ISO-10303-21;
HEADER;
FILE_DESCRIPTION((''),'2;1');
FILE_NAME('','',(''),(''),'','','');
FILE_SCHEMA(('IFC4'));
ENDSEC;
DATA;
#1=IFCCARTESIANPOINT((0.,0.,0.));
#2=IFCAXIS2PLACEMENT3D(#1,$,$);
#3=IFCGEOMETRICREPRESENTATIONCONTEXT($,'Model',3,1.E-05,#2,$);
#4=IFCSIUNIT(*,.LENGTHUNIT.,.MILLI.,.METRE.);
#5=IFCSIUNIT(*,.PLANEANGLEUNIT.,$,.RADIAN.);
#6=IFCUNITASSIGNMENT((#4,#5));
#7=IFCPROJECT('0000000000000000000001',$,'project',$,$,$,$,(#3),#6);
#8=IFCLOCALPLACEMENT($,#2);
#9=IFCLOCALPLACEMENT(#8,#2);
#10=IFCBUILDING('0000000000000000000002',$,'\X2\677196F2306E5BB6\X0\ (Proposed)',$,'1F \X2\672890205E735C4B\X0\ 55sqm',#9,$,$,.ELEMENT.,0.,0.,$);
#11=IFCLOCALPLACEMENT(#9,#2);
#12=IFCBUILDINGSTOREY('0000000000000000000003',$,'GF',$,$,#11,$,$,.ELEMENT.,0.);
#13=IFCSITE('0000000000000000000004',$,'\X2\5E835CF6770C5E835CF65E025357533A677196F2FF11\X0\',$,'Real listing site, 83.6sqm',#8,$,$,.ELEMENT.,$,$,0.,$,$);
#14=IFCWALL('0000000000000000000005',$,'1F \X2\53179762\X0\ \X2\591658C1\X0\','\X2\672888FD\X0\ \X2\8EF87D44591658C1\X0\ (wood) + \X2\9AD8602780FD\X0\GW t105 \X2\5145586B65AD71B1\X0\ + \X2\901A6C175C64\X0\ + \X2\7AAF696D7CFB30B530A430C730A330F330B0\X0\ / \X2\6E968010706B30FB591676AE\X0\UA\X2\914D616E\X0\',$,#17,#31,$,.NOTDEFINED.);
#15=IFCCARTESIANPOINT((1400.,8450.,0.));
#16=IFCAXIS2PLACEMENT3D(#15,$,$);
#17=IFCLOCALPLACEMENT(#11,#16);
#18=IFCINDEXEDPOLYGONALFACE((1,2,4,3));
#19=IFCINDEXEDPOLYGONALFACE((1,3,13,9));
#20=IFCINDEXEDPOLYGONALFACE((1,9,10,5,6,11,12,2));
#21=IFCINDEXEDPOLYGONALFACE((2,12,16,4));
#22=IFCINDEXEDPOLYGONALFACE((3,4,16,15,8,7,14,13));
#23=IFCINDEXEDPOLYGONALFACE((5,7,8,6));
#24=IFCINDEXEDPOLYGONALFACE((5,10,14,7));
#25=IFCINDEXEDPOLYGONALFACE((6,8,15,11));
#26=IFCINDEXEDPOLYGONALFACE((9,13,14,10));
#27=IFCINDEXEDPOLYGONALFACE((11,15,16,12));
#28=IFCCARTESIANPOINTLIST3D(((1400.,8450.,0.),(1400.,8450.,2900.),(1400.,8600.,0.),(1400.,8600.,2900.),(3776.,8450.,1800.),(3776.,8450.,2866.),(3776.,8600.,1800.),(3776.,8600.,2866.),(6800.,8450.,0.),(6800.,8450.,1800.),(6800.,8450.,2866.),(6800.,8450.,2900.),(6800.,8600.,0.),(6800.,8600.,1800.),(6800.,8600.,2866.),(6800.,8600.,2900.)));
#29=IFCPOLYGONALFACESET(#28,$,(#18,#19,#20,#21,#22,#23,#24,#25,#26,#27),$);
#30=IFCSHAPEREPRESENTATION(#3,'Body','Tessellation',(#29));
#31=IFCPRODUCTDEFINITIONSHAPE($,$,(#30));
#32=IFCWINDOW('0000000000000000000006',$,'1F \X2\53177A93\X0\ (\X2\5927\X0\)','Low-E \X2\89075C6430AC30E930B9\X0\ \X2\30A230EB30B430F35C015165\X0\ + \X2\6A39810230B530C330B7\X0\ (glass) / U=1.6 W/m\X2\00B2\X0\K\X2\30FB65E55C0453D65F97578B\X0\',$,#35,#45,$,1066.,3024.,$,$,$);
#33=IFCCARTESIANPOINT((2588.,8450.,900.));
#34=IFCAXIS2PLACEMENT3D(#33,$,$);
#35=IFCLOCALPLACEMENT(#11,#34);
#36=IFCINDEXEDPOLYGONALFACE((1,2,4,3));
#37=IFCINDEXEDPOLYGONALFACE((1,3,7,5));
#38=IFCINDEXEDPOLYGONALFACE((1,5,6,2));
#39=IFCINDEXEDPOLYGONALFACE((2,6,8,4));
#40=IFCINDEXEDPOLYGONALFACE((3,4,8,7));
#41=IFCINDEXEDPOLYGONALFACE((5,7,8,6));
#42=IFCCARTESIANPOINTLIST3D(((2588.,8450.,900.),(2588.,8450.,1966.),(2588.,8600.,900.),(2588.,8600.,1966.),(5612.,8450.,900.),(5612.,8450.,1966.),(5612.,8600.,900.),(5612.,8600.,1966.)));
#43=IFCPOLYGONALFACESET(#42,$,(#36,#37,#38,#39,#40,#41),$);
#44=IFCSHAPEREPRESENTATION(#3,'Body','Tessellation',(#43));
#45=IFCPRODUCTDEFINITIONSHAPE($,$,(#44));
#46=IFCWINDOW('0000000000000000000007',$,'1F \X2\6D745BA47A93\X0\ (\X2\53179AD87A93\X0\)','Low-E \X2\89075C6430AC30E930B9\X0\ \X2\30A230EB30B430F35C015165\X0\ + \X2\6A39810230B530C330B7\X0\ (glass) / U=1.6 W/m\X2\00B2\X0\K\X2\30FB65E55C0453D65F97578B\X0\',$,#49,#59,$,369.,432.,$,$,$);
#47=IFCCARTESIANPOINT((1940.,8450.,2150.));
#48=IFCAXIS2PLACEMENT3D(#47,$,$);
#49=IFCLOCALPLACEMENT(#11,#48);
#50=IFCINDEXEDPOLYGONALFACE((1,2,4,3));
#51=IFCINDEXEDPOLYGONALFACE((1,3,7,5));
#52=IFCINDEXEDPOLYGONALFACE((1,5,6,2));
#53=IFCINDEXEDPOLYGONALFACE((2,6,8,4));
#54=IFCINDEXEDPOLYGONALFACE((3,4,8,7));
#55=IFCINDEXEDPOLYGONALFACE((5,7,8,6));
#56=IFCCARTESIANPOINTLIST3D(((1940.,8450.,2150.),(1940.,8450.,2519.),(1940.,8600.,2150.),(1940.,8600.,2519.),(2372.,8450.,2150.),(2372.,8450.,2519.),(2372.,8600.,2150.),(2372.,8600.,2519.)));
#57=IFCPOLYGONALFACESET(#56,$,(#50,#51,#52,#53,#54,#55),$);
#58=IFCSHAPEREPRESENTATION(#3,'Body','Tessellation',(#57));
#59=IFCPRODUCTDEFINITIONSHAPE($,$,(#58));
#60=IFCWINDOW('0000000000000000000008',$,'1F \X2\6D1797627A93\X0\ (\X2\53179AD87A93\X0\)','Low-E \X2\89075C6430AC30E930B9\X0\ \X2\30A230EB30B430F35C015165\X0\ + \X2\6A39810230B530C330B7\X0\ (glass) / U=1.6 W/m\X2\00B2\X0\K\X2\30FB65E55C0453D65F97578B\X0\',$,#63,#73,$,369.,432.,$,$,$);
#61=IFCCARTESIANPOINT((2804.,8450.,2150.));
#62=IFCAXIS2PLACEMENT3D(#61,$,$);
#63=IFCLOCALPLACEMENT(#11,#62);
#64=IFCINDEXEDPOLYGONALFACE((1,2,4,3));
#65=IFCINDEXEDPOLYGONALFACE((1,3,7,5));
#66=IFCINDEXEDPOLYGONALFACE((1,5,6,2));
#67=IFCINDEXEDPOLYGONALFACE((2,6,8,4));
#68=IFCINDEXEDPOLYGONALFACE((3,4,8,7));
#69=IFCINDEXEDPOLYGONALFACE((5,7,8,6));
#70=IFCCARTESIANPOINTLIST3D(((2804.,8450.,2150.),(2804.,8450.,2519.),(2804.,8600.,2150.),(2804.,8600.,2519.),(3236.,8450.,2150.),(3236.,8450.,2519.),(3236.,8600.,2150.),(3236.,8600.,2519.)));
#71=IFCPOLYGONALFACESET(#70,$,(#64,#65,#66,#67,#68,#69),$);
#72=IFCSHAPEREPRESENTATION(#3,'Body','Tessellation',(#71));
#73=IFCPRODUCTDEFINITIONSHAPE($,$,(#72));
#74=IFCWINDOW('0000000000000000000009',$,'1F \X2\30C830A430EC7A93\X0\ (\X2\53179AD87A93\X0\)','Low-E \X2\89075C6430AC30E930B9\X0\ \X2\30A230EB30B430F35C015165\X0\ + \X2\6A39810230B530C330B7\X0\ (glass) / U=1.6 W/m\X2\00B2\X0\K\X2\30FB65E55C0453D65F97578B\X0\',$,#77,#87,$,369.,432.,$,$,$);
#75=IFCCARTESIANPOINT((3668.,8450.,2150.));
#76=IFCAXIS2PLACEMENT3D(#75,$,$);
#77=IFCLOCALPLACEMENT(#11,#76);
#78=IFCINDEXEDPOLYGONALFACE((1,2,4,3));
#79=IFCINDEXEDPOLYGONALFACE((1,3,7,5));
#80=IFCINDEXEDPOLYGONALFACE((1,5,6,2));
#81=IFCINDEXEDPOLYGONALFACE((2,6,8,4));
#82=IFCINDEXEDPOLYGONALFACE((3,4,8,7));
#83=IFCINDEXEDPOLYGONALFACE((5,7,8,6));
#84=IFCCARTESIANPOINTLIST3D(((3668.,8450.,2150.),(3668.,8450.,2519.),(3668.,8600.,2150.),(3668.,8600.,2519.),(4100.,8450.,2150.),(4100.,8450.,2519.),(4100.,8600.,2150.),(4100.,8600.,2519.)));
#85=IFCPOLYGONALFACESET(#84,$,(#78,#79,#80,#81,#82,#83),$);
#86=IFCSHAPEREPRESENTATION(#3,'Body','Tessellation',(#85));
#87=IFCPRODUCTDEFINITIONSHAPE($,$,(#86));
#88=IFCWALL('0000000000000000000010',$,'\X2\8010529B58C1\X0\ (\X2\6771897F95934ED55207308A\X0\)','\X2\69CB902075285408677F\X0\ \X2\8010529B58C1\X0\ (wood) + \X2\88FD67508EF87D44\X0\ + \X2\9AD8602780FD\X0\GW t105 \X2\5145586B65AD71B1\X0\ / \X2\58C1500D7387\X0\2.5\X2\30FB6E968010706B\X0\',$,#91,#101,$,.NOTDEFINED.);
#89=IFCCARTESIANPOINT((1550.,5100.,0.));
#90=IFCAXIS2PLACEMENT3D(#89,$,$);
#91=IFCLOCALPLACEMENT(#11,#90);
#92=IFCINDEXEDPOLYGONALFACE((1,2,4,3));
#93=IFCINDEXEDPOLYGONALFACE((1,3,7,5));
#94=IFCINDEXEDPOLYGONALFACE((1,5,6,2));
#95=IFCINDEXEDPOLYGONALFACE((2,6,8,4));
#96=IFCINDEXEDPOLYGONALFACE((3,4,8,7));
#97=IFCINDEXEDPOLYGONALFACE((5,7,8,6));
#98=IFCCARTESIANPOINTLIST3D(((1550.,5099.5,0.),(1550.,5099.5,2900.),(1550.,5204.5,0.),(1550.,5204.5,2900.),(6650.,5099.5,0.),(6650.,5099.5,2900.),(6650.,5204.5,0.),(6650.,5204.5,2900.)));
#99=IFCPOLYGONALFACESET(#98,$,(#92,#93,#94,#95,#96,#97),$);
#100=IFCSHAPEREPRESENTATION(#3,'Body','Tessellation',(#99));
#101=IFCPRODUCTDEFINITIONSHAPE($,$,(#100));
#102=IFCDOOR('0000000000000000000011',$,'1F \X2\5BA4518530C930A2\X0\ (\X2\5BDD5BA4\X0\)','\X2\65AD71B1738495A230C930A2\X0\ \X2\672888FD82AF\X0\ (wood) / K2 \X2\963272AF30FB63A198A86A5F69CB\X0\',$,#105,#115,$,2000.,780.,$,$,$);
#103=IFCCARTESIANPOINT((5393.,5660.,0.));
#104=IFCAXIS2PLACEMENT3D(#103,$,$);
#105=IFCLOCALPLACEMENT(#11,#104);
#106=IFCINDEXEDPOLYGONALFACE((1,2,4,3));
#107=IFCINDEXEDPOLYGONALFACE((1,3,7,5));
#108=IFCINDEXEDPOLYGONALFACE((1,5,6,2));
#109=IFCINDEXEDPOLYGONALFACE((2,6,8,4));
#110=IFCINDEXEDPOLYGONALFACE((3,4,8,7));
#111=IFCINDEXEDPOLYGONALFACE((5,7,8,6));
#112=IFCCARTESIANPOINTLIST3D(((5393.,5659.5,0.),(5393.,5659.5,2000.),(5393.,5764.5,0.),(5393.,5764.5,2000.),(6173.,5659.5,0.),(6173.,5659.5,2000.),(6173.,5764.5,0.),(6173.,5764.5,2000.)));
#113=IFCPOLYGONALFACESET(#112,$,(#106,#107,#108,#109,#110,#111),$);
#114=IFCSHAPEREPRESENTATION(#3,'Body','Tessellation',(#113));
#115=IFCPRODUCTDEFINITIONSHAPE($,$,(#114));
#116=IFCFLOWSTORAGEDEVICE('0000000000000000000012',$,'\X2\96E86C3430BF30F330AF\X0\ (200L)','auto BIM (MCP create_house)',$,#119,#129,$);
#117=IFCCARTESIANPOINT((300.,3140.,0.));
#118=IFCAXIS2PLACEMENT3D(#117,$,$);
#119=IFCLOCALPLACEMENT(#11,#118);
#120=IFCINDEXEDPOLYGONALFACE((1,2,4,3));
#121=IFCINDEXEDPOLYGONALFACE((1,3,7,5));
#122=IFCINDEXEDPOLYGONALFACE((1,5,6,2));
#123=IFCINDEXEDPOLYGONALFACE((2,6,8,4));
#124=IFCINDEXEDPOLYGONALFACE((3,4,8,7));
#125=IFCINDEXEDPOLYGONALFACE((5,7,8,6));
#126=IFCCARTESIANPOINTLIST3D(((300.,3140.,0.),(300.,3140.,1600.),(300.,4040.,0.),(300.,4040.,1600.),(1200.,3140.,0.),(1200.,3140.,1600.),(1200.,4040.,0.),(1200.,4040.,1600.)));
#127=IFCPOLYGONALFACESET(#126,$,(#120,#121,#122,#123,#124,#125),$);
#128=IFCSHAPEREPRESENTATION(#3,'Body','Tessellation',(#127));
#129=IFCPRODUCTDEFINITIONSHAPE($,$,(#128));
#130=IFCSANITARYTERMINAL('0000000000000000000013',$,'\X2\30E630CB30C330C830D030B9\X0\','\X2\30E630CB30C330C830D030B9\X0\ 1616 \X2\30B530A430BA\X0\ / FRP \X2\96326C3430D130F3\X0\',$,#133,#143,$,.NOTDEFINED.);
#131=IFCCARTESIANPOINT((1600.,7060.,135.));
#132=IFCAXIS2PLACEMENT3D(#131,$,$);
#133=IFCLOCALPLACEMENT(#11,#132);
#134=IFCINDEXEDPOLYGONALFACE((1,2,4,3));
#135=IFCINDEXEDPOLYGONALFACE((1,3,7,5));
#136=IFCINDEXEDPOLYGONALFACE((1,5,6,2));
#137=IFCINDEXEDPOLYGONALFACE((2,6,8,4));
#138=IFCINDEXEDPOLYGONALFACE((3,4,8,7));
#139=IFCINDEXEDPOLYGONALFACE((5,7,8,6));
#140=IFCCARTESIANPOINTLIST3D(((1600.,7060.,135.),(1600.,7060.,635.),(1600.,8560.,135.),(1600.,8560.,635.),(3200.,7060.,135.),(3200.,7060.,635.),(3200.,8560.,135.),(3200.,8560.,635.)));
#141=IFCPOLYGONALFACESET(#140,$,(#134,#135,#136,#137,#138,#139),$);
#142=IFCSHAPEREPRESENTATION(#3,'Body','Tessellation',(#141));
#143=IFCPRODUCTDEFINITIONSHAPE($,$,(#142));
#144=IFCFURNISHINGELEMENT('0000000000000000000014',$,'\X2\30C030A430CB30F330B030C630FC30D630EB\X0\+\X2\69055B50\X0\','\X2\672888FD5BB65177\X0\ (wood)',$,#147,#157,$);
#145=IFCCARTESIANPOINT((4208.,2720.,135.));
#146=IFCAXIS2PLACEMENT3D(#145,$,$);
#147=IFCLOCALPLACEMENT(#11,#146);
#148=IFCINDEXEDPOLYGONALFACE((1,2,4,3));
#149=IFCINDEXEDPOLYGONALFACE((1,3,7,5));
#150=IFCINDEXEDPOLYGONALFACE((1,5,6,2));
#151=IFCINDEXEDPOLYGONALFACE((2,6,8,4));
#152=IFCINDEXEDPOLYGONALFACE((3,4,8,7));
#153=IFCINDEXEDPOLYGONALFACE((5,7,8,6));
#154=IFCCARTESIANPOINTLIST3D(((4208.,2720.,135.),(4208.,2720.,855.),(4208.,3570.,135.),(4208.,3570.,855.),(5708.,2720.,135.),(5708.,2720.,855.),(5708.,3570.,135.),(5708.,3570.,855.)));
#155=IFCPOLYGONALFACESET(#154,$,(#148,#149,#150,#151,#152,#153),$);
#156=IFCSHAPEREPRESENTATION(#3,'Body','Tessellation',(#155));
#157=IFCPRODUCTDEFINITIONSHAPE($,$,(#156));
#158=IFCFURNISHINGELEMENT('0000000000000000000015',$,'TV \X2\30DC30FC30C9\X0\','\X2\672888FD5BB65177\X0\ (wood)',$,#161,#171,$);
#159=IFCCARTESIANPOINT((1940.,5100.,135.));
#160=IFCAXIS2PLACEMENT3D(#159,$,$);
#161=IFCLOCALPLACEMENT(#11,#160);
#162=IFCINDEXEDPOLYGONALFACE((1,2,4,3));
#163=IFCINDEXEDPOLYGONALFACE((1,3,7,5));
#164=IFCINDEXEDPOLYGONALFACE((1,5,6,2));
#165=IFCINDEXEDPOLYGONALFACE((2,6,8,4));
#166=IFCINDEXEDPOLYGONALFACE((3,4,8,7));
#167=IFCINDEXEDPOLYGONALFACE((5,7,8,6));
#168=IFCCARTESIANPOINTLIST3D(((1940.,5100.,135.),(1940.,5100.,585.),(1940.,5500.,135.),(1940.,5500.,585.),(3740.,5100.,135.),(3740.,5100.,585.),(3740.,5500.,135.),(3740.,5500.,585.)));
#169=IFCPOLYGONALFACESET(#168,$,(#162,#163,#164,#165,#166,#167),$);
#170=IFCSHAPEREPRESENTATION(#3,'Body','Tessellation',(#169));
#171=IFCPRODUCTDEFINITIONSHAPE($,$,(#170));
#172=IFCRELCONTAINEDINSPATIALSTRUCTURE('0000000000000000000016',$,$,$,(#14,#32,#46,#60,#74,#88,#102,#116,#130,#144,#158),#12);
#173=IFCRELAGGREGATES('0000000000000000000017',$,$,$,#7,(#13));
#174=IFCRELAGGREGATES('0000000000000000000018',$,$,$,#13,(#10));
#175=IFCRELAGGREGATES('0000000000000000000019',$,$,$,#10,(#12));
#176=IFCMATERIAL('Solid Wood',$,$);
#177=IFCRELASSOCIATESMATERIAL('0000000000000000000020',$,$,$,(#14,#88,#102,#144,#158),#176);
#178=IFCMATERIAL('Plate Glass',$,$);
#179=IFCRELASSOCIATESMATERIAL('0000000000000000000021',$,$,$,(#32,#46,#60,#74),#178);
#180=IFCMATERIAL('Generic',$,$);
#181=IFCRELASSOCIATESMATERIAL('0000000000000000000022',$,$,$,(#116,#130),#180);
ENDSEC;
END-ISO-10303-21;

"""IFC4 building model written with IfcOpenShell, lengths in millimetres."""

from ifc_helpers import new_model, si_unit, frame, frame_2d, origin, place, context, project, spatial, rectangle, extrude, material, element, fill, save


model = new_model("IFC4")

# Units and contexts
model_context = context("Model", 3, precision=1e-05, world=origin())
ifc_project = project(units=[si_unit("LENGTHUNIT", "METRE", prefix="MILLI"), si_unit("PLANEANGLEUNIT", "RADIAN")], contexts=[model_context])

# Site, building, storey
site_placement = place(None, origin())
site = spatial("IfcSite", under=ifc_project, at=site_placement, Name="広島県広島市南区東雲１", ObjectType="Real listing site, 83.6sqm", CompositionType="ELEMENT", RefElevation=0.0)
building_placement = place(site_placement, origin())
building = spatial("IfcBuilding", under=site, at=building_placement, Name="東雲の家 (Proposed)", ObjectType="1F 木造平屋 55sqm", CompositionType="ELEMENT", ElevationOfRefHeight=0.0, ElevationOfTerrain=0.0)
storey_placement = place(building_placement, origin())
storey = spatial("IfcBuildingStorey", under=building, at=storey_placement, Name="GF", CompositionType="ELEMENT", Elevation=0.0)

# Wall, openings, windows
ifc_material_1 = material(Name="Solid Wood")
wall_1_placement = place(storey_placement, frame((1400.0, 8450.0, 0.0)))
wall_1 = element("IfcWall", 1, at=wall_1_placement, inside=storey, material=ifc_material_1, Name="1F 北面 外壁", Description="木製 軸組外壁 (wood) + 高性能GW t105 充填断熱 + 通気層 + 窯業系サイディング / 準耐火・外皮UA配慮", PredefinedType="NOTDEFINED", context=model_context, shape_type="SweptSolid", body=[
    extrude(rectangle(XDim=5400.0, YDim=150.0, at=frame_2d((2700.0, 75.0))), frame((1400.0, 8450.0, 0.0)), (0.0, 0.0, 1.0), 2900.0),
])
opening_1_placement = place(storey_placement, frame((2588.0, 8450.0, 900.0)))
opening_1 = element("IfcOpeningElement", 2, at=opening_1_placement, cuts=wall_1, PredefinedType="NOTDEFINED", context=model_context, shape_type="SweptSolid", body=[
    extrude(rectangle(XDim=3024.0, YDim=150.0, at=frame_2d((1512.0, 75.0))), frame((2588.0, 8450.0, 900.0)), (0.0, 0.0, 1.0), 1066.0),
])
opening_2_placement = place(storey_placement, frame((1940.0, 8450.0, 2150.0)))
opening_2 = element("IfcOpeningElement", 3, at=opening_2_placement, cuts=wall_1, PredefinedType="NOTDEFINED", context=model_context, shape_type="SweptSolid", body=[
    extrude(rectangle(XDim=432.0, YDim=150.0, at=frame_2d((216.0, 75.0))), frame((1940.0, 8450.0, 2150.0)), (0.0, 0.0, 1.0), 369.0),
])
opening_3_placement = place(storey_placement, frame((2804.0, 8450.0, 2150.0)))
opening_3 = element("IfcOpeningElement", 4, at=opening_3_placement, cuts=wall_1, PredefinedType="NOTDEFINED", context=model_context, shape_type="SweptSolid", body=[
    extrude(rectangle(XDim=432.0, YDim=150.0, at=frame_2d((216.0, 75.0))), frame((2804.0, 8450.0, 2150.0)), (0.0, 0.0, 1.0), 369.0),
])
opening_4_placement = place(storey_placement, frame((3668.0, 8450.0, 2150.0)))
opening_4 = element("IfcOpeningElement", 5, at=opening_4_placement, cuts=wall_1, PredefinedType="NOTDEFINED", context=model_context, shape_type="SweptSolid", body=[
    extrude(rectangle(XDim=432.0, YDim=150.0, at=frame_2d((216.0, 75.0))), frame((3668.0, 8450.0, 2150.0)), (0.0, 0.0, 1.0), 369.0),
])
ifc_material_2 = material(Name="Plate Glass")
window_1_placement = place(storey_placement, frame((2588.0, 8450.0, 900.0)))
window_1 = element("IfcWindow", 6, at=window_1_placement, inside=storey, material=ifc_material_2, Name="1F 北窓 (大)", Description="Low-E 複層ガラス アルゴン封入 + 樹脂サッシ (glass) / U=1.6 W/m²K・日射取得型", OverallHeight=1066.0, OverallWidth=3024.0, context=model_context, shape_type="SweptSolid", body=[
    extrude(rectangle(XDim=3024.0, YDim=150.0, at=frame_2d((1512.0, 75.0))), frame((2588.0, 8450.0, 900.0)), (0.0, 0.0, 1.0), 1066.0),
])
fill(opening_1, window_1)
window_2_placement = place(storey_placement, frame((1940.0, 8450.0, 2150.0)))
window_2 = element("IfcWindow", 7, at=window_2_placement, inside=storey, material=ifc_material_2, Name="1F 浴室窓 (北高窓)", Description="Low-E 複層ガラス アルゴン封入 + 樹脂サッシ (glass) / U=1.6 W/m²K・日射取得型", OverallHeight=369.0, OverallWidth=432.0, context=model_context, shape_type="SweptSolid", body=[
    extrude(rectangle(XDim=432.0, YDim=150.0, at=frame_2d((216.0, 75.0))), frame((1940.0, 8450.0, 2150.0)), (0.0, 0.0, 1.0), 369.0),
])
fill(opening_2, window_2)
window_3_placement = place(storey_placement, frame((2804.0, 8450.0, 2150.0)))
window_3 = element("IfcWindow", 8, at=window_3_placement, inside=storey, material=ifc_material_2, Name="1F 洗面窓 (北高窓)", Description="Low-E 複層ガラス アルゴン封入 + 樹脂サッシ (glass) / U=1.6 W/m²K・日射取得型", OverallHeight=369.0, OverallWidth=432.0, context=model_context, shape_type="SweptSolid", body=[
    extrude(rectangle(XDim=432.0, YDim=150.0, at=frame_2d((216.0, 75.0))), frame((2804.0, 8450.0, 2150.0)), (0.0, 0.0, 1.0), 369.0),
])
fill(opening_3, window_3)
window_4_placement = place(storey_placement, frame((3668.0, 8450.0, 2150.0)))
window_4 = element("IfcWindow", 9, at=window_4_placement, inside=storey, material=ifc_material_2, Name="1F トイレ窓 (北高窓)", Description="Low-E 複層ガラス アルゴン封入 + 樹脂サッシ (glass) / U=1.6 W/m²K・日射取得型", OverallHeight=369.0, OverallWidth=432.0, context=model_context, shape_type="SweptSolid", body=[
    extrude(rectangle(XDim=432.0, YDim=150.0, at=frame_2d((216.0, 75.0))), frame((3668.0, 8450.0, 2150.0)), (0.0, 0.0, 1.0), 369.0),
])
fill(opening_4, window_4)

# Wall
wall_2_placement = place(storey_placement, frame((1550.0, 5100.0, 0.0)))
element("IfcWall", 10, at=wall_2_placement, inside=storey, material=ifc_material_1, Name="耐力壁 (東西間仕切り)", Description="構造用合板 耐力壁 (wood) + 製材軸組 + 高性能GW t105 充填断熱 / 壁倍率2.5・準耐火", PredefinedType="NOTDEFINED", context=model_context, shape_type="SweptSolid", body=[
    extrude(rectangle(XDim=5100.0, YDim=105.0, at=frame_2d((2550.0, 52.0))), frame((1550.0, 5100.0, 0.0)), (0.0, 0.0, 1.0), 2900.0),
])

# Door
door_1_placement = place(storey_placement, frame((5393.0, 5660.0, 0.0)))
element("IfcDoor", 11, at=door_1_placement, inside=storey, material=ifc_material_1, Name="1F 室内ドア (寝室)", Description="断熱玄関ドア 木製芯 (wood) / K2 防犯・採風機構", OverallHeight=2000.0, OverallWidth=780.0, context=model_context, shape_type="SweptSolid", body=[
    extrude(rectangle(XDim=780.0, YDim=105.0, at=frame_2d((390.0, 52.0))), frame((5393.0, 5660.0, 0.0)), (0.0, 0.0, 1.0), 2000.0),
])

# Flow storage device
ifc_material_3 = material(Name="Generic")
flow_storage_device_placement = place(storey_placement, frame((300.0, 3140.0, 0.0)))
element("IfcFlowStorageDevice", 12, at=flow_storage_device_placement, inside=storey, material=ifc_material_3, Name="雨水タンク (200L)", Description="auto BIM (MCP create_house)", context=model_context, shape_type="SweptSolid", body=[
    extrude(rectangle(XDim=900.0, YDim=900.0, at=frame_2d((450.0, 450.0))), frame((300.0, 3140.0, 0.0)), (0.0, 0.0, 1.0), 1600.0),
])

# Sanitary terminal
sanitary_terminal_placement = place(storey_placement, frame((1600.0, 7060.0, 135.0)))
element("IfcSanitaryTerminal", 13, at=sanitary_terminal_placement, inside=storey, material=ifc_material_3, Name="ユニットバス", Description="ユニットバス 1616 サイズ / FRP 防水パン", PredefinedType="NOTDEFINED", context=model_context, shape_type="SweptSolid", body=[
    extrude(rectangle(XDim=1600.0, YDim=1500.0, at=frame_2d((800.0, 750.0))), frame((1600.0, 7060.0, 135.0)), (0.0, 0.0, 1.0), 500.0),
])

# Furnishing elements
furnishing_1_placement = place(storey_placement, frame((4208.0, 2720.0, 135.0)))
element("IfcFurnishingElement", 14, at=furnishing_1_placement, inside=storey, material=ifc_material_1, Name="ダイニングテーブル+椅子", Description="木製家具 (wood)", context=model_context, shape_type="SweptSolid", body=[
    extrude(rectangle(XDim=1500.0, YDim=850.0, at=frame_2d((750.0, 425.0))), frame((4208.0, 2720.0, 135.0)), (0.0, 0.0, 1.0), 720.0),
])
furnishing_2_placement = place(storey_placement, frame((1940.0, 5100.0, 135.0)))
element("IfcFurnishingElement", 15, at=furnishing_2_placement, inside=storey, material=ifc_material_1, Name="TV ボード", Description="木製家具 (wood)", context=model_context, shape_type="SweptSolid", body=[
    extrude(rectangle(XDim=1800.0, YDim=400.0, at=frame_2d((900.0, 200.0))), frame((1940.0, 5100.0, 135.0)), (0.0, 0.0, 1.0), 450.0),
])

save(model, "model.ifc")
